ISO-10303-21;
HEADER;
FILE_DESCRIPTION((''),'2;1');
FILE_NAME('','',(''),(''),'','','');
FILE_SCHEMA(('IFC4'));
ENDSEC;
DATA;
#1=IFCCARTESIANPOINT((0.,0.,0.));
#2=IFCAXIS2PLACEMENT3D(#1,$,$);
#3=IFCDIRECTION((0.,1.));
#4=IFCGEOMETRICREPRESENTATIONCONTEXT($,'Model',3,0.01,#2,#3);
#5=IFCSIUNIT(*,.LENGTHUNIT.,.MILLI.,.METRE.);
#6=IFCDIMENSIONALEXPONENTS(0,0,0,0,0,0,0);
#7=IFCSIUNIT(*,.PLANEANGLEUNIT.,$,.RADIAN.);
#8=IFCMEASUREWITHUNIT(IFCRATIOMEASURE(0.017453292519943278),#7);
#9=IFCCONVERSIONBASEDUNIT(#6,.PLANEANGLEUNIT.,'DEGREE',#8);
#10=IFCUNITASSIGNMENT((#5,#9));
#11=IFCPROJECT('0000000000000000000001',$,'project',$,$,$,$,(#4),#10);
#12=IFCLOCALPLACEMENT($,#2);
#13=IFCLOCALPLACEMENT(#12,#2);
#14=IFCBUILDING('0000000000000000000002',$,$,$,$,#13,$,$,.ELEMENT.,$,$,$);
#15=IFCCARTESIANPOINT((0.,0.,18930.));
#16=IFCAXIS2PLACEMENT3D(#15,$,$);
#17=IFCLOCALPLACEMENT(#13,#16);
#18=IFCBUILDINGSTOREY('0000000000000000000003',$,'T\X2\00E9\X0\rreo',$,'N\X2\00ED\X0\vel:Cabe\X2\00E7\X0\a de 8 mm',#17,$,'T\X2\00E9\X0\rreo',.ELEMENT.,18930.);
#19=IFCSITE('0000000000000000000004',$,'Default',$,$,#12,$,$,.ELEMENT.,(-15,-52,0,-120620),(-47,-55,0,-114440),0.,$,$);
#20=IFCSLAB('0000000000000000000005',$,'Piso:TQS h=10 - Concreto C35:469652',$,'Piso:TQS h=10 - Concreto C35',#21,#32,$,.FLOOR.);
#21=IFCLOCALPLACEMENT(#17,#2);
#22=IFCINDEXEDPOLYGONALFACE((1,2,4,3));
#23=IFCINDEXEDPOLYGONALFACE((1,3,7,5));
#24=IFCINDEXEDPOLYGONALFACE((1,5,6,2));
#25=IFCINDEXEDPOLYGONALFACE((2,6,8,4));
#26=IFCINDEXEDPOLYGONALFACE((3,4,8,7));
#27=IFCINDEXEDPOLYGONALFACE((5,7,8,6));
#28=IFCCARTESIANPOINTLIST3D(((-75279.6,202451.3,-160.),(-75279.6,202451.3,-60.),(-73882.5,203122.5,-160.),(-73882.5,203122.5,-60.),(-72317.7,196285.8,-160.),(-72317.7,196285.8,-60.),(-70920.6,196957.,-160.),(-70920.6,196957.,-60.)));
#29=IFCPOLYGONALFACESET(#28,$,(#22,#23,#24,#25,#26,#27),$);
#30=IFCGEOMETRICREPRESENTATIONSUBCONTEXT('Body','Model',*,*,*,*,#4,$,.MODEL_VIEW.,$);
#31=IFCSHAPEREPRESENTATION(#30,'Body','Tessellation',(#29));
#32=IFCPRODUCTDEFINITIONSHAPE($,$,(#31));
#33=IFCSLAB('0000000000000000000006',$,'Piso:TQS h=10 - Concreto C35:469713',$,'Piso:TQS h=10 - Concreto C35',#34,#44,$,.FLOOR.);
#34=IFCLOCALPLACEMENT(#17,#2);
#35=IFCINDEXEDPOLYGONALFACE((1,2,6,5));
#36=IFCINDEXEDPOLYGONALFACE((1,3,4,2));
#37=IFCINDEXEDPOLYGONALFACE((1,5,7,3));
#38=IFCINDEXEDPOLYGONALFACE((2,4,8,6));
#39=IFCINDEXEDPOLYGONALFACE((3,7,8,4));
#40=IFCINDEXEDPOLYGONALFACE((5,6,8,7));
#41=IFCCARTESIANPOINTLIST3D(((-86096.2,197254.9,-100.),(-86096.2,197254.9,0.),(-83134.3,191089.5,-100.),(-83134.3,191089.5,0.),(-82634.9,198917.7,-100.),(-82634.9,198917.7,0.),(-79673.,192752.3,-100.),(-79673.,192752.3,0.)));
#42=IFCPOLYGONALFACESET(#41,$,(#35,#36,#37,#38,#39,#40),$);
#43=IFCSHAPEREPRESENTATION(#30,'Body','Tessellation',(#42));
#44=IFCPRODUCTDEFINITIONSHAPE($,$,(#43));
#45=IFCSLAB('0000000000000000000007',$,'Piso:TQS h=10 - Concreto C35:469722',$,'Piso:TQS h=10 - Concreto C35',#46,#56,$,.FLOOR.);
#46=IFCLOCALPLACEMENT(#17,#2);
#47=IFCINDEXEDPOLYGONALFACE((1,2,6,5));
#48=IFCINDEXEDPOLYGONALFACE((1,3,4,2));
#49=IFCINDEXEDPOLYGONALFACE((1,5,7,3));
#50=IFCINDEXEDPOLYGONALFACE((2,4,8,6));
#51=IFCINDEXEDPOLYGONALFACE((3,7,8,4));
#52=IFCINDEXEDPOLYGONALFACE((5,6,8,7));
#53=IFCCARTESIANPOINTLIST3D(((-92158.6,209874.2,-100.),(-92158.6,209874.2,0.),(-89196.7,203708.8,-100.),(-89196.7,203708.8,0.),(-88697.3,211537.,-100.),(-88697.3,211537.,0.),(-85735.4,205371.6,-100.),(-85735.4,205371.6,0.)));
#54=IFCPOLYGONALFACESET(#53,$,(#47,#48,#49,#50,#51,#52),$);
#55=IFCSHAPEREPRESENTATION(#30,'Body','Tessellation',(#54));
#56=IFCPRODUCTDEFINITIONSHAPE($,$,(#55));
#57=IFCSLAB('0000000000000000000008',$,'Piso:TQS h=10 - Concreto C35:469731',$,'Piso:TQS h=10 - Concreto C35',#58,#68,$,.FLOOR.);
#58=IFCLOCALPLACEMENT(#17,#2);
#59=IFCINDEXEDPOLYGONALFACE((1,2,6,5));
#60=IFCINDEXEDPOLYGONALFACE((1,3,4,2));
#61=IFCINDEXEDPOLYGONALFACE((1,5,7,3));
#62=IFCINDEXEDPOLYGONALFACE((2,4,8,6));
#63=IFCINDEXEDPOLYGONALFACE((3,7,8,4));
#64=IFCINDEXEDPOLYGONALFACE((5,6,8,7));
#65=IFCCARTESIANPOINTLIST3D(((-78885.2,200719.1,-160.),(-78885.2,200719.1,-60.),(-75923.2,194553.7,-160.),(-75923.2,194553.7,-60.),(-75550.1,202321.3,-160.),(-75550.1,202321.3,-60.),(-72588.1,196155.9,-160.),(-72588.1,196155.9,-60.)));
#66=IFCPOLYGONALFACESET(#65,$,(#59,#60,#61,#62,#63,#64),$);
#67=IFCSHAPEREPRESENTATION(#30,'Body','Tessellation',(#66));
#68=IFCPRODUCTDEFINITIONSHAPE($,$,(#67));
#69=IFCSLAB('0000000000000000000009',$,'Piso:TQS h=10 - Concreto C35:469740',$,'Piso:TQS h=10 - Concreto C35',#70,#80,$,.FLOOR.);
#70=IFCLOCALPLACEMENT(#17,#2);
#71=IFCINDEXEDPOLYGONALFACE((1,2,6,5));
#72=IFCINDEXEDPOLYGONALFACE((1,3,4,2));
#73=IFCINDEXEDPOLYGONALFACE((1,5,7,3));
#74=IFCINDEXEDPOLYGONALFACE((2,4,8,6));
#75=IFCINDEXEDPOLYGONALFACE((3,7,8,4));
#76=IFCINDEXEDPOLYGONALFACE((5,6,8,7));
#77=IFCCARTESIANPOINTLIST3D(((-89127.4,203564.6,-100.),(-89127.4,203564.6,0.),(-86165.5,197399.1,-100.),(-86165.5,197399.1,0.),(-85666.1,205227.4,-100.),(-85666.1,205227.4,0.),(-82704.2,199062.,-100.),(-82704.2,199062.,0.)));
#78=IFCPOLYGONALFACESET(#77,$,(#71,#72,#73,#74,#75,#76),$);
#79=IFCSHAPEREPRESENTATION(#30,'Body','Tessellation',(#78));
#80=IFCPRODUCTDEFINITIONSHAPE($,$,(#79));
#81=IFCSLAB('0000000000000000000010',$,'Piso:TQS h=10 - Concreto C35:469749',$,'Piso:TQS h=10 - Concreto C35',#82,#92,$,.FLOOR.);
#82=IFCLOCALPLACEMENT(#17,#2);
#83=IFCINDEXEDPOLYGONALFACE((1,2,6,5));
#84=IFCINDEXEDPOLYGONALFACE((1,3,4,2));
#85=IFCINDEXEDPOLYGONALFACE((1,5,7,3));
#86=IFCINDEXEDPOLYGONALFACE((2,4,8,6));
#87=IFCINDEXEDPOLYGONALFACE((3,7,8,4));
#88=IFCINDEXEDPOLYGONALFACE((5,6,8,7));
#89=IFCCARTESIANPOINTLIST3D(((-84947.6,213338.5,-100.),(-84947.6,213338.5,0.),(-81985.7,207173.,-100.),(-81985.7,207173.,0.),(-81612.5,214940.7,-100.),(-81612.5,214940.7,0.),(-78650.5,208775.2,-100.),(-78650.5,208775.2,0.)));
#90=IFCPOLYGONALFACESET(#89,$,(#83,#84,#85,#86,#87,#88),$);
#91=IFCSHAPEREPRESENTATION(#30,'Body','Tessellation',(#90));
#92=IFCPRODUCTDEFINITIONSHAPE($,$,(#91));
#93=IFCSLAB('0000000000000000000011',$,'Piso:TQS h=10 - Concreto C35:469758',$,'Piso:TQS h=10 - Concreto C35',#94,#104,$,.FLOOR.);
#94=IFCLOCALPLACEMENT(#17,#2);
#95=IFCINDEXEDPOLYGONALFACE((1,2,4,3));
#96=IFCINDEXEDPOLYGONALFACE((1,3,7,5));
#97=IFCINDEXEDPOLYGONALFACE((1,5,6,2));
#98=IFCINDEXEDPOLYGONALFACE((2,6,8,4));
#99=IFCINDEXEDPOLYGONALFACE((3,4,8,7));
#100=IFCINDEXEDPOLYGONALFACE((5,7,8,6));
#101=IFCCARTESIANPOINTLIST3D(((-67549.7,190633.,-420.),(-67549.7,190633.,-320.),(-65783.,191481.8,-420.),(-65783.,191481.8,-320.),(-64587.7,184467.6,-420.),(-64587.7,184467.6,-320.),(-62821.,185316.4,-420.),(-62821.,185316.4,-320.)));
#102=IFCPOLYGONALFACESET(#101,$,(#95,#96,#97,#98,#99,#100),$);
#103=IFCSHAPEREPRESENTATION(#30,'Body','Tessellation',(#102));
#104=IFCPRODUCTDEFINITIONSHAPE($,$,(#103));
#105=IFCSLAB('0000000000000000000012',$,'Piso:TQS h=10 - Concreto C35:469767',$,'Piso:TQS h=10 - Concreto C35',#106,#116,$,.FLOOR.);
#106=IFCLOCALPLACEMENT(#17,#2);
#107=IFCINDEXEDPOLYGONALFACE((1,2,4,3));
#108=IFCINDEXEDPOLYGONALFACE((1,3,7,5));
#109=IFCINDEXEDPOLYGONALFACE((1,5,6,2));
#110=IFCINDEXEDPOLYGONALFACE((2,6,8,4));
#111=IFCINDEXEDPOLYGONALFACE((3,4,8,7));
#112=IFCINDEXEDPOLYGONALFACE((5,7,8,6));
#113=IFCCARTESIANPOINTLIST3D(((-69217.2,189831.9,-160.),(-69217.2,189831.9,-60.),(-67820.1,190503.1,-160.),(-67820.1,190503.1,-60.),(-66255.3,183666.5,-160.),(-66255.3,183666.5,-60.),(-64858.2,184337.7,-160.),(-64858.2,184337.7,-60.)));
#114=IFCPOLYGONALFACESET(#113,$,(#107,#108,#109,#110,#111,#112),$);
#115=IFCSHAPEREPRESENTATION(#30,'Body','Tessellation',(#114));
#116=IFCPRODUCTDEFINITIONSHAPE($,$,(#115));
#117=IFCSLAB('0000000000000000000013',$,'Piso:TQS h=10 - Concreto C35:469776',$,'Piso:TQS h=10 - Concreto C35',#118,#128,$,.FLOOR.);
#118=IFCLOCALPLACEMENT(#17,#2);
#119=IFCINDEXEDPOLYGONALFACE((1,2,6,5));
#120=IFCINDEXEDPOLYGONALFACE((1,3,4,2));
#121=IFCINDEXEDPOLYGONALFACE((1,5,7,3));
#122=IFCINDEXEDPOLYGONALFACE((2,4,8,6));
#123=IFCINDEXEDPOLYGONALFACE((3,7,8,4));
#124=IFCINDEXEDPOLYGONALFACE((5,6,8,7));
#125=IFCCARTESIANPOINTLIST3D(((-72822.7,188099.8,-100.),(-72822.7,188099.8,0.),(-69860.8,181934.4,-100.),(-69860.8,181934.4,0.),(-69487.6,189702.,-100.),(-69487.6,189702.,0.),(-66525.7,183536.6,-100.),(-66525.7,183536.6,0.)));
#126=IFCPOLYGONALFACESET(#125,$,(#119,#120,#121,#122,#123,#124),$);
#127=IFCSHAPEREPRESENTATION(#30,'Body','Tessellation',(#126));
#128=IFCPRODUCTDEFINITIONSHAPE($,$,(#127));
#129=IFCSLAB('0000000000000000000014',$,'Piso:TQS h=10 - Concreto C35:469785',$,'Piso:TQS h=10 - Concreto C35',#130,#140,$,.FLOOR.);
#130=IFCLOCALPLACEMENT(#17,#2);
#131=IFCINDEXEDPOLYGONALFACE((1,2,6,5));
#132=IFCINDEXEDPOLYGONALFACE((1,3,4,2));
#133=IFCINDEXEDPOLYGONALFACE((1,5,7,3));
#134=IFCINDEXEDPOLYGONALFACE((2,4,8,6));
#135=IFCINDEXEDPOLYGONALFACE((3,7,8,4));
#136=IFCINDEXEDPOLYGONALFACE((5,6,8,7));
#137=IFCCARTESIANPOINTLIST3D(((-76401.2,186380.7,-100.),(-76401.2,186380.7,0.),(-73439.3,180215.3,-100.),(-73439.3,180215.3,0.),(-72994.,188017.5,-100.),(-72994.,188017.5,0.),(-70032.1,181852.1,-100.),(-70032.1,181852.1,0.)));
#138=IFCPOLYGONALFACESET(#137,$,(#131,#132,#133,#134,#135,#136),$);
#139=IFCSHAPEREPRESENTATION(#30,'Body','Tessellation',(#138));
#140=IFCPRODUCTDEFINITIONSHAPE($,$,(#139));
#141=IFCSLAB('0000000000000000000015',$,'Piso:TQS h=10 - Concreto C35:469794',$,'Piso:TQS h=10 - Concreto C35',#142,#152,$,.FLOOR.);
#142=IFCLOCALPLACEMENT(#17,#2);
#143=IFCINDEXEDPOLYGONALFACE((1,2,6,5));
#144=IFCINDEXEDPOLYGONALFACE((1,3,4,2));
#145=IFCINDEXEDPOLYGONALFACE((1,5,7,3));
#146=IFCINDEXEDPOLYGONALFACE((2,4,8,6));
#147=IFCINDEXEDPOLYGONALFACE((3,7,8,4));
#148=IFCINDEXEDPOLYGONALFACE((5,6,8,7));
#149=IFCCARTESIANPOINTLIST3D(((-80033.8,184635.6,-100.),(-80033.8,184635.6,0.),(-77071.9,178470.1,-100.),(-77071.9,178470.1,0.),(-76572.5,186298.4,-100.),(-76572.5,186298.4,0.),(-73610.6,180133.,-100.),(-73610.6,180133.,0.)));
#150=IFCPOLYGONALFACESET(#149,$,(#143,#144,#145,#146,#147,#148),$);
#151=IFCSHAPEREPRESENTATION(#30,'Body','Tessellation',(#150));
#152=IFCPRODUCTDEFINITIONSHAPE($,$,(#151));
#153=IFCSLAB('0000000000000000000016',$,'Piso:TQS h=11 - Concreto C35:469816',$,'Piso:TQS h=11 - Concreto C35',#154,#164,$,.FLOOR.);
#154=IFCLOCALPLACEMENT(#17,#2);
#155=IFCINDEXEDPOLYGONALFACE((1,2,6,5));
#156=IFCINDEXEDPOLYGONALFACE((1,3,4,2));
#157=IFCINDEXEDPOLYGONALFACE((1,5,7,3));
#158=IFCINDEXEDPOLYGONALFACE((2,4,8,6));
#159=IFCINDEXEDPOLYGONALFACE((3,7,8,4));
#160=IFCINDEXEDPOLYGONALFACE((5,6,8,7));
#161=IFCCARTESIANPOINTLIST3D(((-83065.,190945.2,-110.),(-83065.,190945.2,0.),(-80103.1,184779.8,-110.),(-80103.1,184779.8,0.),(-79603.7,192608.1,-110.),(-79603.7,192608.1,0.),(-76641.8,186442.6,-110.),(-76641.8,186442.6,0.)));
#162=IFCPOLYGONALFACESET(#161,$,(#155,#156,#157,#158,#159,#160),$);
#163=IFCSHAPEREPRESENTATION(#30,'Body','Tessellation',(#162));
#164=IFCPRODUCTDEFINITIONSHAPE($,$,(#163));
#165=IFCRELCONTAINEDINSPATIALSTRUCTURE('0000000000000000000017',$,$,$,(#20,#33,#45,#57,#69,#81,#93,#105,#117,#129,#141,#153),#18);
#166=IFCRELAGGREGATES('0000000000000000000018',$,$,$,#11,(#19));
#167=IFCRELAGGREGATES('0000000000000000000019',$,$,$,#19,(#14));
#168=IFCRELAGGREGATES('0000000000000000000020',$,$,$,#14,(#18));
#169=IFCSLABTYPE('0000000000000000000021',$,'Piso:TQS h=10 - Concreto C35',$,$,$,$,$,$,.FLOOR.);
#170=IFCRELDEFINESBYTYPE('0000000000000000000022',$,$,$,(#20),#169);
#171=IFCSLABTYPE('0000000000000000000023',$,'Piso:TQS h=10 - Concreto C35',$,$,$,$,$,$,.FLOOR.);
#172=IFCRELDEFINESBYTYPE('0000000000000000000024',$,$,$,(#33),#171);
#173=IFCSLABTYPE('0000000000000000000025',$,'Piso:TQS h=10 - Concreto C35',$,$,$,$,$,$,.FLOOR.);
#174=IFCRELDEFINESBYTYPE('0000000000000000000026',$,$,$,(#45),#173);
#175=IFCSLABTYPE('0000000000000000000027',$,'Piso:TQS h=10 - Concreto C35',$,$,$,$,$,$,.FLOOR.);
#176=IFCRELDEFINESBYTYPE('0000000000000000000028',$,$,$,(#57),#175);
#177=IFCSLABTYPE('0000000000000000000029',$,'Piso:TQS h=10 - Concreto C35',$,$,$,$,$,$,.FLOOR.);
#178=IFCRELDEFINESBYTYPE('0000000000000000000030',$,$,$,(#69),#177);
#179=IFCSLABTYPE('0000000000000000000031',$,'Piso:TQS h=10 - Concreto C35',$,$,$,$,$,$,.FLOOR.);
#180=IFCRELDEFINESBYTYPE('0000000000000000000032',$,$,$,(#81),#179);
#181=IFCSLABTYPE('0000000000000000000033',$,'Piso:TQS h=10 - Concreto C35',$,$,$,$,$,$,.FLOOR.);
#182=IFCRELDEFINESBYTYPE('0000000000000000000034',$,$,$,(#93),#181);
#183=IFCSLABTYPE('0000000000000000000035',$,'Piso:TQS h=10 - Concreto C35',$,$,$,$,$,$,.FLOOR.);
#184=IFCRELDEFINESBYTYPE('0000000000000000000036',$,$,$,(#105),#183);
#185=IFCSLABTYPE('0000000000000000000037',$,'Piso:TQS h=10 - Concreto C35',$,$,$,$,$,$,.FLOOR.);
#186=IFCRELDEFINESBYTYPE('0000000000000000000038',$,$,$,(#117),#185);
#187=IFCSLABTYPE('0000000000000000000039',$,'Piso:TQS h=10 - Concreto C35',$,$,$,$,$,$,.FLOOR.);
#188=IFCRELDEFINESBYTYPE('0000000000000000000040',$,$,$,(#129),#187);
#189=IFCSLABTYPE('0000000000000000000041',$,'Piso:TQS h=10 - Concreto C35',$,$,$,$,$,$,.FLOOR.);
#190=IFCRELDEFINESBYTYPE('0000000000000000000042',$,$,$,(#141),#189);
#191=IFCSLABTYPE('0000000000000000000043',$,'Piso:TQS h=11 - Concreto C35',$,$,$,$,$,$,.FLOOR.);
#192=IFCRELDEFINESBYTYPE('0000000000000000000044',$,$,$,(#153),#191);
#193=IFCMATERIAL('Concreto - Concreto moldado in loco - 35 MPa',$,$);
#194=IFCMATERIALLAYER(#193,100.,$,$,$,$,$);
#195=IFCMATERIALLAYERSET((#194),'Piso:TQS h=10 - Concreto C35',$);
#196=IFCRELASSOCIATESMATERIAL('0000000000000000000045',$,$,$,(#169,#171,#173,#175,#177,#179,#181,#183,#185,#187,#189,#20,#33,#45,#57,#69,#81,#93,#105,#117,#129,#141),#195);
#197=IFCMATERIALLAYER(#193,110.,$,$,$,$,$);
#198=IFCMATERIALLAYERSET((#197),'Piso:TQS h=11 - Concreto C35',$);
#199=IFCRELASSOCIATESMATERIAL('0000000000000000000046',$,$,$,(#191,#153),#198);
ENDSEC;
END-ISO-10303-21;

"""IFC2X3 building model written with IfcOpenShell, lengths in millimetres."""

from ifc_helpers import new_model, entity, si_unit, converted_unit, direction, frame, frame_2d, origin, place, context, subcontext, project, spatial, rectangle, extrude, material, layer, layer_set, layer_usage, type_object, element, save


model = new_model("IFC2X3")

# Units and contexts
model_context = context("Model", 3, precision=0.01, world=origin(), true_north=direction((0.0, 1.0)))
body_context = subcontext(model_context, "Body", "Model", "MODEL_VIEW")
ifc_project = project(units=[si_unit("LENGTHUNIT", "METRE", prefix="MILLI"), converted_unit("PLANEANGLEUNIT", "DEGREE", entity("IfcRatioMeasure", 0.017453292519943278), si_unit("PLANEANGLEUNIT", "RADIAN"), dimensions=[0, 0, 0, 0, 0, 0, 0])], contexts=[model_context])

# Site, building, storey
site_placement = place(None, origin())
site = spatial("IfcSite", under=ifc_project, at=site_placement, Name="Default", CompositionType="ELEMENT", RefLatitude=(-15, -52, 0, -120620), RefLongitude=(-47, -55, 0, -114440), RefElevation=0.0)
building_placement = place(site_placement, origin())
building = spatial("IfcBuilding", under=site, at=building_placement, CompositionType="ELEMENT")
storey_placement = place(building_placement, frame((0.0, 0.0, 18930.0)))
storey = spatial("IfcBuildingStorey", under=building, at=storey_placement, Name="Térreo", ObjectType="Nível:Cabeça de 8 mm", LongName="Térreo", CompositionType="ELEMENT", Elevation=18930.0)

# Shared definitions
ifc_material_1 = material(Name="Concreto - Concreto moldado in loco - 35 MPa")

# Slabs
ifc_layer_1 = layer(ifc_material_1, 110.0)
ifc_layer_set_1 = layer_set([ifc_layer_1], Name="Piso:TQS h=11 - Concreto C35")
ifc_layer_2 = layer(ifc_material_1, 100.0)
ifc_layer_set_2 = layer_set([ifc_layer_2], Name="Piso:TQS h=10 - Concreto C35")
ifc_layer_usage_1 = layer_usage(ifc_layer_set_2, "AXIS3", "POSITIVE", 0.0)
slab_type_1 = type_object("IfcSlabType", Name="Piso:TQS h=10 - Concreto C35", PredefinedType="FLOOR", material=ifc_layer_set_2)
slab_1_placement = place(storey_placement, origin())
element("IfcSlab", 1, at=slab_1_placement, inside=storey, type_object=slab_type_1, material=ifc_layer_usage_1, Name="Piso:TQS h=10 - Concreto C35:469652", ObjectType="Piso:TQS h=10 - Concreto C35", PredefinedType="FLOOR", context=body_context, shape_type="SweptSolid", body=[
    extrude(rectangle(XDim=6840.0, YDim=1550.0, at=frame_2d((0.0, 0.0), x_axis=(1.0, 0.0))), frame((-73100.1, 199704.1, -60.0), z_axis=(0.0, 0.0, -1.0), x_axis=(0.43303, -0.90138, 0.0)), (0.0, 0.0, 1.0), 100.0),
])
ifc_layer_usage_2 = layer_usage(ifc_layer_set_2, "AXIS3", "POSITIVE", 0.0)
slab_type_2 = type_object("IfcSlabType", Name="Piso:TQS h=10 - Concreto C35", PredefinedType="FLOOR", material=ifc_layer_set_2)
slab_2_placement = place(storey_placement, origin())
element("IfcSlab", 2, at=slab_2_placement, inside=storey, type_object=slab_type_2, material=ifc_layer_usage_2, Name="Piso:TQS h=10 - Concreto C35:469713", ObjectType="Piso:TQS h=10 - Concreto C35", PredefinedType="FLOOR", context=body_context, shape_type="SweptSolid", body=[
    extrude(rectangle(XDim=6840.0, YDim=3840.0, at=frame_2d((0.0, 0.0), x_axis=(1.0, 0.0))), frame((-82884.6, 195003.6, 0.0), z_axis=(0.0, 0.0, -1.0), x_axis=(0.43303, -0.90138, 0.0)), (0.0, 0.0, 1.0), 100.0),
])
ifc_layer_usage_3 = layer_usage(ifc_layer_set_2, "AXIS3", "POSITIVE", 0.0)
slab_type_3 = type_object("IfcSlabType", Name="Piso:TQS h=10 - Concreto C35", PredefinedType="FLOOR", material=ifc_layer_set_2)
slab_3_placement = place(storey_placement, origin())
element("IfcSlab", 3, at=slab_3_placement, inside=storey, type_object=slab_type_3, material=ifc_layer_usage_3, Name="Piso:TQS h=10 - Concreto C35:469722", ObjectType="Piso:TQS h=10 - Concreto C35", PredefinedType="FLOOR", context=body_context, shape_type="SweptSolid", body=[
    extrude(rectangle(XDim=6840.0, YDim=3840.0, at=frame_2d((0.0, 0.0), x_axis=(1.0, 0.0))), frame((-88947.0, 207622.9, 0.0), z_axis=(0.0, 0.0, -1.0), x_axis=(0.43303, -0.90138, 0.0)), (0.0, 0.0, 1.0), 100.0),
])
ifc_layer_usage_4 = layer_usage(ifc_layer_set_2, "AXIS3", "POSITIVE", 0.0)
slab_type_4 = type_object("IfcSlabType", Name="Piso:TQS h=10 - Concreto C35", PredefinedType="FLOOR", material=ifc_layer_set_2)
slab_4_placement = place(storey_placement, origin())
element("IfcSlab", 4, at=slab_4_placement, inside=storey, type_object=slab_type_4, material=ifc_layer_usage_4, Name="Piso:TQS h=10 - Concreto C35:469731", ObjectType="Piso:TQS h=10 - Concreto C35", PredefinedType="FLOOR", context=body_context, shape_type="SweptSolid", body=[
    extrude(rectangle(XDim=6840.0, YDim=3700.0, at=frame_2d((0.0, 0.0), x_axis=(1.0, 0.0))), frame((-75736.6, 198437.5, -60.0), z_axis=(0.0, 0.0, -1.0), x_axis=(0.43303, -0.90138, 0.0)), (0.0, 0.0, 1.0), 100.0),
])
ifc_layer_usage_5 = layer_usage(ifc_layer_set_2, "AXIS3", "POSITIVE", 0.0)
slab_type_5 = type_object("IfcSlabType", Name="Piso:TQS h=10 - Concreto C35", PredefinedType="FLOOR", material=ifc_layer_set_2)
slab_5_placement = place(storey_placement, origin())
element("IfcSlab", 5, at=slab_5_placement, inside=storey, type_object=slab_type_5, material=ifc_layer_usage_5, Name="Piso:TQS h=10 - Concreto C35:469740", ObjectType="Piso:TQS h=10 - Concreto C35", PredefinedType="FLOOR", context=body_context, shape_type="SweptSolid", body=[
    extrude(rectangle(XDim=6840.0, YDim=3840.0, at=frame_2d((0.0, 0.0), x_axis=(1.0, 0.0))), frame((-85915.8, 201313.3, 0.0), z_axis=(0.0, 0.0, -1.0), x_axis=(0.43303, -0.90138, 0.0)), (0.0, 0.0, 1.0), 100.0),
])
ifc_layer_usage_6 = layer_usage(ifc_layer_set_2, "AXIS3", "POSITIVE", 0.0)
slab_type_6 = type_object("IfcSlabType", Name="Piso:TQS h=10 - Concreto C35", PredefinedType="FLOOR", material=ifc_layer_set_2)
slab_6_placement = place(storey_placement, origin())
element("IfcSlab", 6, at=slab_6_placement, inside=storey, type_object=slab_type_6, material=ifc_layer_usage_6, Name="Piso:TQS h=10 - Concreto C35:469749", ObjectType="Piso:TQS h=10 - Concreto C35", PredefinedType="FLOOR", context=body_context, shape_type="SweptSolid", body=[
    extrude(rectangle(XDim=6840.0, YDim=3700.0, at=frame_2d((0.0, 0.0), x_axis=(1.0, 0.0))), frame((-81799.1, 211056.8, 0.0), z_axis=(0.0, 0.0, -1.0), x_axis=(0.43303, -0.90138, 0.0)), (0.0, 0.0, 1.0), 100.0),
])
ifc_layer_usage_7 = layer_usage(ifc_layer_set_2, "AXIS3", "POSITIVE", 0.0)
slab_type_7 = type_object("IfcSlabType", Name="Piso:TQS h=10 - Concreto C35", PredefinedType="FLOOR", material=ifc_layer_set_2)
slab_7_placement = place(storey_placement, origin())
element("IfcSlab", 7, at=slab_7_placement, inside=storey, type_object=slab_type_7, material=ifc_layer_usage_7, Name="Piso:TQS h=10 - Concreto C35:469758", ObjectType="Piso:TQS h=10 - Concreto C35", PredefinedType="FLOOR", context=body_context, shape_type="SweptSolid", body=[
    extrude(rectangle(XDim=1960.0, YDim=6840.0, at=frame_2d((0.0, 0.0), x_axis=(1.0, 0.0))), frame((-65185.4, 187974.7, -320.0), z_axis=(0.0, 0.0, -1.0), x_axis=(0.90138, 0.43303, 0.0)), (0.0, 0.0, 1.0), 100.0),
])
ifc_layer_usage_8 = layer_usage(ifc_layer_set_2, "AXIS3", "POSITIVE", 0.0)
slab_type_8 = type_object("IfcSlabType", Name="Piso:TQS h=10 - Concreto C35", PredefinedType="FLOOR", material=ifc_layer_set_2)
slab_8_placement = place(storey_placement, origin())
element("IfcSlab", 8, at=slab_8_placement, inside=storey, type_object=slab_type_8, material=ifc_layer_usage_8, Name="Piso:TQS h=10 - Concreto C35:469767", ObjectType="Piso:TQS h=10 - Concreto C35", PredefinedType="FLOOR", context=body_context, shape_type="SweptSolid", body=[
    extrude(rectangle(XDim=1550.0, YDim=6840.0, at=frame_2d((0.0, 0.0), x_axis=(1.0, 0.0))), frame((-67037.7, 187084.8, -60.0), z_axis=(0.0, 0.0, -1.0), x_axis=(0.90138, 0.43303, 0.0)), (0.0, 0.0, 1.0), 100.0),
])
ifc_layer_usage_9 = layer_usage(ifc_layer_set_2, "AXIS3", "POSITIVE", 0.0)
slab_type_9 = type_object("IfcSlabType", Name="Piso:TQS h=10 - Concreto C35", PredefinedType="FLOOR", material=ifc_layer_set_2)
slab_9_placement = place(storey_placement, origin())
element("IfcSlab", 9, at=slab_9_placement, inside=storey, type_object=slab_type_9, material=ifc_layer_usage_9, Name="Piso:TQS h=10 - Concreto C35:469776", ObjectType="Piso:TQS h=10 - Concreto C35", PredefinedType="FLOOR", context=body_context, shape_type="SweptSolid", body=[
    extrude(rectangle(XDim=6840.0, YDim=3700.0, at=frame_2d((0.0, 0.0), x_axis=(1.0, 0.0))), frame((-69674.2, 185818.2, 0.0), z_axis=(0.0, 0.0, -1.0), x_axis=(0.43303, -0.90138, 0.0)), (0.0, 0.0, 1.0), 100.0),
])
ifc_layer_usage_10 = layer_usage(ifc_layer_set_2, "AXIS3", "POSITIVE", 0.0)
slab_type_10 = type_object("IfcSlabType", Name="Piso:TQS h=10 - Concreto C35", PredefinedType="FLOOR", material=ifc_layer_set_2)
slab_10_placement = place(storey_placement, origin())
element("IfcSlab", 10, at=slab_10_placement, inside=storey, type_object=slab_type_10, material=ifc_layer_usage_10, Name="Piso:TQS h=10 - Concreto C35:469785", ObjectType="Piso:TQS h=10 - Concreto C35", PredefinedType="FLOOR", context=body_context, shape_type="SweptSolid", body=[
    extrude(rectangle(XDim=6840.0, YDim=3780.0, at=frame_2d((0.0, 0.0), x_axis=(1.0, 0.0))), frame((-73216.7, 184116.4, 0.0), z_axis=(0.0, 0.0, -1.0), x_axis=(0.43303, -0.90138, 0.0)), (0.0, 0.0, 1.0), 100.0),
])
ifc_layer_usage_11 = layer_usage(ifc_layer_set_2, "AXIS3", "POSITIVE", 0.0)
slab_type_11 = type_object("IfcSlabType", Name="Piso:TQS h=10 - Concreto C35", PredefinedType="FLOOR", material=ifc_layer_set_2)
slab_11_placement = place(storey_placement, origin())
element("IfcSlab", 11, at=slab_11_placement, inside=storey, type_object=slab_type_11, material=ifc_layer_usage_11, Name="Piso:TQS h=10 - Concreto C35:469794", ObjectType="Piso:TQS h=10 - Concreto C35", PredefinedType="FLOOR", context=body_context, shape_type="SweptSolid", body=[
    extrude(rectangle(XDim=6840.0, YDim=3840.0, at=frame_2d((0.0, 0.0), x_axis=(1.0, 0.0))), frame((-76822.2, 182384.3, 0.0), z_axis=(0.0, 0.0, -1.0), x_axis=(0.43303, -0.90138, 0.0)), (0.0, 0.0, 1.0), 100.0),
])
ifc_layer_usage_12 = layer_usage(ifc_layer_set_1, "AXIS3", "POSITIVE", 0.0)
slab_type_12 = type_object("IfcSlabType", Name="Piso:TQS h=11 - Concreto C35", PredefinedType="FLOOR", material=ifc_layer_set_1)
slab_12_placement = place(storey_placement, origin())
element("IfcSlab", 12, at=slab_12_placement, inside=storey, type_object=slab_type_12, material=ifc_layer_usage_12, Name="Piso:TQS h=11 - Concreto C35:469816", ObjectType="Piso:TQS h=11 - Concreto C35", PredefinedType="FLOOR", context=body_context, shape_type="SweptSolid", body=[
    extrude(rectangle(XDim=6840.0, YDim=3840.0, at=frame_2d((0.0, 0.0), x_axis=(1.0, 0.0))), frame((-79853.4, 188693.9, 0.0), z_axis=(0.0, 0.0, -1.0), x_axis=(0.43303, -0.90138, 0.0)), (0.0, 0.0, 1.0), 110.0),
])

save(model, "model.ifc")
